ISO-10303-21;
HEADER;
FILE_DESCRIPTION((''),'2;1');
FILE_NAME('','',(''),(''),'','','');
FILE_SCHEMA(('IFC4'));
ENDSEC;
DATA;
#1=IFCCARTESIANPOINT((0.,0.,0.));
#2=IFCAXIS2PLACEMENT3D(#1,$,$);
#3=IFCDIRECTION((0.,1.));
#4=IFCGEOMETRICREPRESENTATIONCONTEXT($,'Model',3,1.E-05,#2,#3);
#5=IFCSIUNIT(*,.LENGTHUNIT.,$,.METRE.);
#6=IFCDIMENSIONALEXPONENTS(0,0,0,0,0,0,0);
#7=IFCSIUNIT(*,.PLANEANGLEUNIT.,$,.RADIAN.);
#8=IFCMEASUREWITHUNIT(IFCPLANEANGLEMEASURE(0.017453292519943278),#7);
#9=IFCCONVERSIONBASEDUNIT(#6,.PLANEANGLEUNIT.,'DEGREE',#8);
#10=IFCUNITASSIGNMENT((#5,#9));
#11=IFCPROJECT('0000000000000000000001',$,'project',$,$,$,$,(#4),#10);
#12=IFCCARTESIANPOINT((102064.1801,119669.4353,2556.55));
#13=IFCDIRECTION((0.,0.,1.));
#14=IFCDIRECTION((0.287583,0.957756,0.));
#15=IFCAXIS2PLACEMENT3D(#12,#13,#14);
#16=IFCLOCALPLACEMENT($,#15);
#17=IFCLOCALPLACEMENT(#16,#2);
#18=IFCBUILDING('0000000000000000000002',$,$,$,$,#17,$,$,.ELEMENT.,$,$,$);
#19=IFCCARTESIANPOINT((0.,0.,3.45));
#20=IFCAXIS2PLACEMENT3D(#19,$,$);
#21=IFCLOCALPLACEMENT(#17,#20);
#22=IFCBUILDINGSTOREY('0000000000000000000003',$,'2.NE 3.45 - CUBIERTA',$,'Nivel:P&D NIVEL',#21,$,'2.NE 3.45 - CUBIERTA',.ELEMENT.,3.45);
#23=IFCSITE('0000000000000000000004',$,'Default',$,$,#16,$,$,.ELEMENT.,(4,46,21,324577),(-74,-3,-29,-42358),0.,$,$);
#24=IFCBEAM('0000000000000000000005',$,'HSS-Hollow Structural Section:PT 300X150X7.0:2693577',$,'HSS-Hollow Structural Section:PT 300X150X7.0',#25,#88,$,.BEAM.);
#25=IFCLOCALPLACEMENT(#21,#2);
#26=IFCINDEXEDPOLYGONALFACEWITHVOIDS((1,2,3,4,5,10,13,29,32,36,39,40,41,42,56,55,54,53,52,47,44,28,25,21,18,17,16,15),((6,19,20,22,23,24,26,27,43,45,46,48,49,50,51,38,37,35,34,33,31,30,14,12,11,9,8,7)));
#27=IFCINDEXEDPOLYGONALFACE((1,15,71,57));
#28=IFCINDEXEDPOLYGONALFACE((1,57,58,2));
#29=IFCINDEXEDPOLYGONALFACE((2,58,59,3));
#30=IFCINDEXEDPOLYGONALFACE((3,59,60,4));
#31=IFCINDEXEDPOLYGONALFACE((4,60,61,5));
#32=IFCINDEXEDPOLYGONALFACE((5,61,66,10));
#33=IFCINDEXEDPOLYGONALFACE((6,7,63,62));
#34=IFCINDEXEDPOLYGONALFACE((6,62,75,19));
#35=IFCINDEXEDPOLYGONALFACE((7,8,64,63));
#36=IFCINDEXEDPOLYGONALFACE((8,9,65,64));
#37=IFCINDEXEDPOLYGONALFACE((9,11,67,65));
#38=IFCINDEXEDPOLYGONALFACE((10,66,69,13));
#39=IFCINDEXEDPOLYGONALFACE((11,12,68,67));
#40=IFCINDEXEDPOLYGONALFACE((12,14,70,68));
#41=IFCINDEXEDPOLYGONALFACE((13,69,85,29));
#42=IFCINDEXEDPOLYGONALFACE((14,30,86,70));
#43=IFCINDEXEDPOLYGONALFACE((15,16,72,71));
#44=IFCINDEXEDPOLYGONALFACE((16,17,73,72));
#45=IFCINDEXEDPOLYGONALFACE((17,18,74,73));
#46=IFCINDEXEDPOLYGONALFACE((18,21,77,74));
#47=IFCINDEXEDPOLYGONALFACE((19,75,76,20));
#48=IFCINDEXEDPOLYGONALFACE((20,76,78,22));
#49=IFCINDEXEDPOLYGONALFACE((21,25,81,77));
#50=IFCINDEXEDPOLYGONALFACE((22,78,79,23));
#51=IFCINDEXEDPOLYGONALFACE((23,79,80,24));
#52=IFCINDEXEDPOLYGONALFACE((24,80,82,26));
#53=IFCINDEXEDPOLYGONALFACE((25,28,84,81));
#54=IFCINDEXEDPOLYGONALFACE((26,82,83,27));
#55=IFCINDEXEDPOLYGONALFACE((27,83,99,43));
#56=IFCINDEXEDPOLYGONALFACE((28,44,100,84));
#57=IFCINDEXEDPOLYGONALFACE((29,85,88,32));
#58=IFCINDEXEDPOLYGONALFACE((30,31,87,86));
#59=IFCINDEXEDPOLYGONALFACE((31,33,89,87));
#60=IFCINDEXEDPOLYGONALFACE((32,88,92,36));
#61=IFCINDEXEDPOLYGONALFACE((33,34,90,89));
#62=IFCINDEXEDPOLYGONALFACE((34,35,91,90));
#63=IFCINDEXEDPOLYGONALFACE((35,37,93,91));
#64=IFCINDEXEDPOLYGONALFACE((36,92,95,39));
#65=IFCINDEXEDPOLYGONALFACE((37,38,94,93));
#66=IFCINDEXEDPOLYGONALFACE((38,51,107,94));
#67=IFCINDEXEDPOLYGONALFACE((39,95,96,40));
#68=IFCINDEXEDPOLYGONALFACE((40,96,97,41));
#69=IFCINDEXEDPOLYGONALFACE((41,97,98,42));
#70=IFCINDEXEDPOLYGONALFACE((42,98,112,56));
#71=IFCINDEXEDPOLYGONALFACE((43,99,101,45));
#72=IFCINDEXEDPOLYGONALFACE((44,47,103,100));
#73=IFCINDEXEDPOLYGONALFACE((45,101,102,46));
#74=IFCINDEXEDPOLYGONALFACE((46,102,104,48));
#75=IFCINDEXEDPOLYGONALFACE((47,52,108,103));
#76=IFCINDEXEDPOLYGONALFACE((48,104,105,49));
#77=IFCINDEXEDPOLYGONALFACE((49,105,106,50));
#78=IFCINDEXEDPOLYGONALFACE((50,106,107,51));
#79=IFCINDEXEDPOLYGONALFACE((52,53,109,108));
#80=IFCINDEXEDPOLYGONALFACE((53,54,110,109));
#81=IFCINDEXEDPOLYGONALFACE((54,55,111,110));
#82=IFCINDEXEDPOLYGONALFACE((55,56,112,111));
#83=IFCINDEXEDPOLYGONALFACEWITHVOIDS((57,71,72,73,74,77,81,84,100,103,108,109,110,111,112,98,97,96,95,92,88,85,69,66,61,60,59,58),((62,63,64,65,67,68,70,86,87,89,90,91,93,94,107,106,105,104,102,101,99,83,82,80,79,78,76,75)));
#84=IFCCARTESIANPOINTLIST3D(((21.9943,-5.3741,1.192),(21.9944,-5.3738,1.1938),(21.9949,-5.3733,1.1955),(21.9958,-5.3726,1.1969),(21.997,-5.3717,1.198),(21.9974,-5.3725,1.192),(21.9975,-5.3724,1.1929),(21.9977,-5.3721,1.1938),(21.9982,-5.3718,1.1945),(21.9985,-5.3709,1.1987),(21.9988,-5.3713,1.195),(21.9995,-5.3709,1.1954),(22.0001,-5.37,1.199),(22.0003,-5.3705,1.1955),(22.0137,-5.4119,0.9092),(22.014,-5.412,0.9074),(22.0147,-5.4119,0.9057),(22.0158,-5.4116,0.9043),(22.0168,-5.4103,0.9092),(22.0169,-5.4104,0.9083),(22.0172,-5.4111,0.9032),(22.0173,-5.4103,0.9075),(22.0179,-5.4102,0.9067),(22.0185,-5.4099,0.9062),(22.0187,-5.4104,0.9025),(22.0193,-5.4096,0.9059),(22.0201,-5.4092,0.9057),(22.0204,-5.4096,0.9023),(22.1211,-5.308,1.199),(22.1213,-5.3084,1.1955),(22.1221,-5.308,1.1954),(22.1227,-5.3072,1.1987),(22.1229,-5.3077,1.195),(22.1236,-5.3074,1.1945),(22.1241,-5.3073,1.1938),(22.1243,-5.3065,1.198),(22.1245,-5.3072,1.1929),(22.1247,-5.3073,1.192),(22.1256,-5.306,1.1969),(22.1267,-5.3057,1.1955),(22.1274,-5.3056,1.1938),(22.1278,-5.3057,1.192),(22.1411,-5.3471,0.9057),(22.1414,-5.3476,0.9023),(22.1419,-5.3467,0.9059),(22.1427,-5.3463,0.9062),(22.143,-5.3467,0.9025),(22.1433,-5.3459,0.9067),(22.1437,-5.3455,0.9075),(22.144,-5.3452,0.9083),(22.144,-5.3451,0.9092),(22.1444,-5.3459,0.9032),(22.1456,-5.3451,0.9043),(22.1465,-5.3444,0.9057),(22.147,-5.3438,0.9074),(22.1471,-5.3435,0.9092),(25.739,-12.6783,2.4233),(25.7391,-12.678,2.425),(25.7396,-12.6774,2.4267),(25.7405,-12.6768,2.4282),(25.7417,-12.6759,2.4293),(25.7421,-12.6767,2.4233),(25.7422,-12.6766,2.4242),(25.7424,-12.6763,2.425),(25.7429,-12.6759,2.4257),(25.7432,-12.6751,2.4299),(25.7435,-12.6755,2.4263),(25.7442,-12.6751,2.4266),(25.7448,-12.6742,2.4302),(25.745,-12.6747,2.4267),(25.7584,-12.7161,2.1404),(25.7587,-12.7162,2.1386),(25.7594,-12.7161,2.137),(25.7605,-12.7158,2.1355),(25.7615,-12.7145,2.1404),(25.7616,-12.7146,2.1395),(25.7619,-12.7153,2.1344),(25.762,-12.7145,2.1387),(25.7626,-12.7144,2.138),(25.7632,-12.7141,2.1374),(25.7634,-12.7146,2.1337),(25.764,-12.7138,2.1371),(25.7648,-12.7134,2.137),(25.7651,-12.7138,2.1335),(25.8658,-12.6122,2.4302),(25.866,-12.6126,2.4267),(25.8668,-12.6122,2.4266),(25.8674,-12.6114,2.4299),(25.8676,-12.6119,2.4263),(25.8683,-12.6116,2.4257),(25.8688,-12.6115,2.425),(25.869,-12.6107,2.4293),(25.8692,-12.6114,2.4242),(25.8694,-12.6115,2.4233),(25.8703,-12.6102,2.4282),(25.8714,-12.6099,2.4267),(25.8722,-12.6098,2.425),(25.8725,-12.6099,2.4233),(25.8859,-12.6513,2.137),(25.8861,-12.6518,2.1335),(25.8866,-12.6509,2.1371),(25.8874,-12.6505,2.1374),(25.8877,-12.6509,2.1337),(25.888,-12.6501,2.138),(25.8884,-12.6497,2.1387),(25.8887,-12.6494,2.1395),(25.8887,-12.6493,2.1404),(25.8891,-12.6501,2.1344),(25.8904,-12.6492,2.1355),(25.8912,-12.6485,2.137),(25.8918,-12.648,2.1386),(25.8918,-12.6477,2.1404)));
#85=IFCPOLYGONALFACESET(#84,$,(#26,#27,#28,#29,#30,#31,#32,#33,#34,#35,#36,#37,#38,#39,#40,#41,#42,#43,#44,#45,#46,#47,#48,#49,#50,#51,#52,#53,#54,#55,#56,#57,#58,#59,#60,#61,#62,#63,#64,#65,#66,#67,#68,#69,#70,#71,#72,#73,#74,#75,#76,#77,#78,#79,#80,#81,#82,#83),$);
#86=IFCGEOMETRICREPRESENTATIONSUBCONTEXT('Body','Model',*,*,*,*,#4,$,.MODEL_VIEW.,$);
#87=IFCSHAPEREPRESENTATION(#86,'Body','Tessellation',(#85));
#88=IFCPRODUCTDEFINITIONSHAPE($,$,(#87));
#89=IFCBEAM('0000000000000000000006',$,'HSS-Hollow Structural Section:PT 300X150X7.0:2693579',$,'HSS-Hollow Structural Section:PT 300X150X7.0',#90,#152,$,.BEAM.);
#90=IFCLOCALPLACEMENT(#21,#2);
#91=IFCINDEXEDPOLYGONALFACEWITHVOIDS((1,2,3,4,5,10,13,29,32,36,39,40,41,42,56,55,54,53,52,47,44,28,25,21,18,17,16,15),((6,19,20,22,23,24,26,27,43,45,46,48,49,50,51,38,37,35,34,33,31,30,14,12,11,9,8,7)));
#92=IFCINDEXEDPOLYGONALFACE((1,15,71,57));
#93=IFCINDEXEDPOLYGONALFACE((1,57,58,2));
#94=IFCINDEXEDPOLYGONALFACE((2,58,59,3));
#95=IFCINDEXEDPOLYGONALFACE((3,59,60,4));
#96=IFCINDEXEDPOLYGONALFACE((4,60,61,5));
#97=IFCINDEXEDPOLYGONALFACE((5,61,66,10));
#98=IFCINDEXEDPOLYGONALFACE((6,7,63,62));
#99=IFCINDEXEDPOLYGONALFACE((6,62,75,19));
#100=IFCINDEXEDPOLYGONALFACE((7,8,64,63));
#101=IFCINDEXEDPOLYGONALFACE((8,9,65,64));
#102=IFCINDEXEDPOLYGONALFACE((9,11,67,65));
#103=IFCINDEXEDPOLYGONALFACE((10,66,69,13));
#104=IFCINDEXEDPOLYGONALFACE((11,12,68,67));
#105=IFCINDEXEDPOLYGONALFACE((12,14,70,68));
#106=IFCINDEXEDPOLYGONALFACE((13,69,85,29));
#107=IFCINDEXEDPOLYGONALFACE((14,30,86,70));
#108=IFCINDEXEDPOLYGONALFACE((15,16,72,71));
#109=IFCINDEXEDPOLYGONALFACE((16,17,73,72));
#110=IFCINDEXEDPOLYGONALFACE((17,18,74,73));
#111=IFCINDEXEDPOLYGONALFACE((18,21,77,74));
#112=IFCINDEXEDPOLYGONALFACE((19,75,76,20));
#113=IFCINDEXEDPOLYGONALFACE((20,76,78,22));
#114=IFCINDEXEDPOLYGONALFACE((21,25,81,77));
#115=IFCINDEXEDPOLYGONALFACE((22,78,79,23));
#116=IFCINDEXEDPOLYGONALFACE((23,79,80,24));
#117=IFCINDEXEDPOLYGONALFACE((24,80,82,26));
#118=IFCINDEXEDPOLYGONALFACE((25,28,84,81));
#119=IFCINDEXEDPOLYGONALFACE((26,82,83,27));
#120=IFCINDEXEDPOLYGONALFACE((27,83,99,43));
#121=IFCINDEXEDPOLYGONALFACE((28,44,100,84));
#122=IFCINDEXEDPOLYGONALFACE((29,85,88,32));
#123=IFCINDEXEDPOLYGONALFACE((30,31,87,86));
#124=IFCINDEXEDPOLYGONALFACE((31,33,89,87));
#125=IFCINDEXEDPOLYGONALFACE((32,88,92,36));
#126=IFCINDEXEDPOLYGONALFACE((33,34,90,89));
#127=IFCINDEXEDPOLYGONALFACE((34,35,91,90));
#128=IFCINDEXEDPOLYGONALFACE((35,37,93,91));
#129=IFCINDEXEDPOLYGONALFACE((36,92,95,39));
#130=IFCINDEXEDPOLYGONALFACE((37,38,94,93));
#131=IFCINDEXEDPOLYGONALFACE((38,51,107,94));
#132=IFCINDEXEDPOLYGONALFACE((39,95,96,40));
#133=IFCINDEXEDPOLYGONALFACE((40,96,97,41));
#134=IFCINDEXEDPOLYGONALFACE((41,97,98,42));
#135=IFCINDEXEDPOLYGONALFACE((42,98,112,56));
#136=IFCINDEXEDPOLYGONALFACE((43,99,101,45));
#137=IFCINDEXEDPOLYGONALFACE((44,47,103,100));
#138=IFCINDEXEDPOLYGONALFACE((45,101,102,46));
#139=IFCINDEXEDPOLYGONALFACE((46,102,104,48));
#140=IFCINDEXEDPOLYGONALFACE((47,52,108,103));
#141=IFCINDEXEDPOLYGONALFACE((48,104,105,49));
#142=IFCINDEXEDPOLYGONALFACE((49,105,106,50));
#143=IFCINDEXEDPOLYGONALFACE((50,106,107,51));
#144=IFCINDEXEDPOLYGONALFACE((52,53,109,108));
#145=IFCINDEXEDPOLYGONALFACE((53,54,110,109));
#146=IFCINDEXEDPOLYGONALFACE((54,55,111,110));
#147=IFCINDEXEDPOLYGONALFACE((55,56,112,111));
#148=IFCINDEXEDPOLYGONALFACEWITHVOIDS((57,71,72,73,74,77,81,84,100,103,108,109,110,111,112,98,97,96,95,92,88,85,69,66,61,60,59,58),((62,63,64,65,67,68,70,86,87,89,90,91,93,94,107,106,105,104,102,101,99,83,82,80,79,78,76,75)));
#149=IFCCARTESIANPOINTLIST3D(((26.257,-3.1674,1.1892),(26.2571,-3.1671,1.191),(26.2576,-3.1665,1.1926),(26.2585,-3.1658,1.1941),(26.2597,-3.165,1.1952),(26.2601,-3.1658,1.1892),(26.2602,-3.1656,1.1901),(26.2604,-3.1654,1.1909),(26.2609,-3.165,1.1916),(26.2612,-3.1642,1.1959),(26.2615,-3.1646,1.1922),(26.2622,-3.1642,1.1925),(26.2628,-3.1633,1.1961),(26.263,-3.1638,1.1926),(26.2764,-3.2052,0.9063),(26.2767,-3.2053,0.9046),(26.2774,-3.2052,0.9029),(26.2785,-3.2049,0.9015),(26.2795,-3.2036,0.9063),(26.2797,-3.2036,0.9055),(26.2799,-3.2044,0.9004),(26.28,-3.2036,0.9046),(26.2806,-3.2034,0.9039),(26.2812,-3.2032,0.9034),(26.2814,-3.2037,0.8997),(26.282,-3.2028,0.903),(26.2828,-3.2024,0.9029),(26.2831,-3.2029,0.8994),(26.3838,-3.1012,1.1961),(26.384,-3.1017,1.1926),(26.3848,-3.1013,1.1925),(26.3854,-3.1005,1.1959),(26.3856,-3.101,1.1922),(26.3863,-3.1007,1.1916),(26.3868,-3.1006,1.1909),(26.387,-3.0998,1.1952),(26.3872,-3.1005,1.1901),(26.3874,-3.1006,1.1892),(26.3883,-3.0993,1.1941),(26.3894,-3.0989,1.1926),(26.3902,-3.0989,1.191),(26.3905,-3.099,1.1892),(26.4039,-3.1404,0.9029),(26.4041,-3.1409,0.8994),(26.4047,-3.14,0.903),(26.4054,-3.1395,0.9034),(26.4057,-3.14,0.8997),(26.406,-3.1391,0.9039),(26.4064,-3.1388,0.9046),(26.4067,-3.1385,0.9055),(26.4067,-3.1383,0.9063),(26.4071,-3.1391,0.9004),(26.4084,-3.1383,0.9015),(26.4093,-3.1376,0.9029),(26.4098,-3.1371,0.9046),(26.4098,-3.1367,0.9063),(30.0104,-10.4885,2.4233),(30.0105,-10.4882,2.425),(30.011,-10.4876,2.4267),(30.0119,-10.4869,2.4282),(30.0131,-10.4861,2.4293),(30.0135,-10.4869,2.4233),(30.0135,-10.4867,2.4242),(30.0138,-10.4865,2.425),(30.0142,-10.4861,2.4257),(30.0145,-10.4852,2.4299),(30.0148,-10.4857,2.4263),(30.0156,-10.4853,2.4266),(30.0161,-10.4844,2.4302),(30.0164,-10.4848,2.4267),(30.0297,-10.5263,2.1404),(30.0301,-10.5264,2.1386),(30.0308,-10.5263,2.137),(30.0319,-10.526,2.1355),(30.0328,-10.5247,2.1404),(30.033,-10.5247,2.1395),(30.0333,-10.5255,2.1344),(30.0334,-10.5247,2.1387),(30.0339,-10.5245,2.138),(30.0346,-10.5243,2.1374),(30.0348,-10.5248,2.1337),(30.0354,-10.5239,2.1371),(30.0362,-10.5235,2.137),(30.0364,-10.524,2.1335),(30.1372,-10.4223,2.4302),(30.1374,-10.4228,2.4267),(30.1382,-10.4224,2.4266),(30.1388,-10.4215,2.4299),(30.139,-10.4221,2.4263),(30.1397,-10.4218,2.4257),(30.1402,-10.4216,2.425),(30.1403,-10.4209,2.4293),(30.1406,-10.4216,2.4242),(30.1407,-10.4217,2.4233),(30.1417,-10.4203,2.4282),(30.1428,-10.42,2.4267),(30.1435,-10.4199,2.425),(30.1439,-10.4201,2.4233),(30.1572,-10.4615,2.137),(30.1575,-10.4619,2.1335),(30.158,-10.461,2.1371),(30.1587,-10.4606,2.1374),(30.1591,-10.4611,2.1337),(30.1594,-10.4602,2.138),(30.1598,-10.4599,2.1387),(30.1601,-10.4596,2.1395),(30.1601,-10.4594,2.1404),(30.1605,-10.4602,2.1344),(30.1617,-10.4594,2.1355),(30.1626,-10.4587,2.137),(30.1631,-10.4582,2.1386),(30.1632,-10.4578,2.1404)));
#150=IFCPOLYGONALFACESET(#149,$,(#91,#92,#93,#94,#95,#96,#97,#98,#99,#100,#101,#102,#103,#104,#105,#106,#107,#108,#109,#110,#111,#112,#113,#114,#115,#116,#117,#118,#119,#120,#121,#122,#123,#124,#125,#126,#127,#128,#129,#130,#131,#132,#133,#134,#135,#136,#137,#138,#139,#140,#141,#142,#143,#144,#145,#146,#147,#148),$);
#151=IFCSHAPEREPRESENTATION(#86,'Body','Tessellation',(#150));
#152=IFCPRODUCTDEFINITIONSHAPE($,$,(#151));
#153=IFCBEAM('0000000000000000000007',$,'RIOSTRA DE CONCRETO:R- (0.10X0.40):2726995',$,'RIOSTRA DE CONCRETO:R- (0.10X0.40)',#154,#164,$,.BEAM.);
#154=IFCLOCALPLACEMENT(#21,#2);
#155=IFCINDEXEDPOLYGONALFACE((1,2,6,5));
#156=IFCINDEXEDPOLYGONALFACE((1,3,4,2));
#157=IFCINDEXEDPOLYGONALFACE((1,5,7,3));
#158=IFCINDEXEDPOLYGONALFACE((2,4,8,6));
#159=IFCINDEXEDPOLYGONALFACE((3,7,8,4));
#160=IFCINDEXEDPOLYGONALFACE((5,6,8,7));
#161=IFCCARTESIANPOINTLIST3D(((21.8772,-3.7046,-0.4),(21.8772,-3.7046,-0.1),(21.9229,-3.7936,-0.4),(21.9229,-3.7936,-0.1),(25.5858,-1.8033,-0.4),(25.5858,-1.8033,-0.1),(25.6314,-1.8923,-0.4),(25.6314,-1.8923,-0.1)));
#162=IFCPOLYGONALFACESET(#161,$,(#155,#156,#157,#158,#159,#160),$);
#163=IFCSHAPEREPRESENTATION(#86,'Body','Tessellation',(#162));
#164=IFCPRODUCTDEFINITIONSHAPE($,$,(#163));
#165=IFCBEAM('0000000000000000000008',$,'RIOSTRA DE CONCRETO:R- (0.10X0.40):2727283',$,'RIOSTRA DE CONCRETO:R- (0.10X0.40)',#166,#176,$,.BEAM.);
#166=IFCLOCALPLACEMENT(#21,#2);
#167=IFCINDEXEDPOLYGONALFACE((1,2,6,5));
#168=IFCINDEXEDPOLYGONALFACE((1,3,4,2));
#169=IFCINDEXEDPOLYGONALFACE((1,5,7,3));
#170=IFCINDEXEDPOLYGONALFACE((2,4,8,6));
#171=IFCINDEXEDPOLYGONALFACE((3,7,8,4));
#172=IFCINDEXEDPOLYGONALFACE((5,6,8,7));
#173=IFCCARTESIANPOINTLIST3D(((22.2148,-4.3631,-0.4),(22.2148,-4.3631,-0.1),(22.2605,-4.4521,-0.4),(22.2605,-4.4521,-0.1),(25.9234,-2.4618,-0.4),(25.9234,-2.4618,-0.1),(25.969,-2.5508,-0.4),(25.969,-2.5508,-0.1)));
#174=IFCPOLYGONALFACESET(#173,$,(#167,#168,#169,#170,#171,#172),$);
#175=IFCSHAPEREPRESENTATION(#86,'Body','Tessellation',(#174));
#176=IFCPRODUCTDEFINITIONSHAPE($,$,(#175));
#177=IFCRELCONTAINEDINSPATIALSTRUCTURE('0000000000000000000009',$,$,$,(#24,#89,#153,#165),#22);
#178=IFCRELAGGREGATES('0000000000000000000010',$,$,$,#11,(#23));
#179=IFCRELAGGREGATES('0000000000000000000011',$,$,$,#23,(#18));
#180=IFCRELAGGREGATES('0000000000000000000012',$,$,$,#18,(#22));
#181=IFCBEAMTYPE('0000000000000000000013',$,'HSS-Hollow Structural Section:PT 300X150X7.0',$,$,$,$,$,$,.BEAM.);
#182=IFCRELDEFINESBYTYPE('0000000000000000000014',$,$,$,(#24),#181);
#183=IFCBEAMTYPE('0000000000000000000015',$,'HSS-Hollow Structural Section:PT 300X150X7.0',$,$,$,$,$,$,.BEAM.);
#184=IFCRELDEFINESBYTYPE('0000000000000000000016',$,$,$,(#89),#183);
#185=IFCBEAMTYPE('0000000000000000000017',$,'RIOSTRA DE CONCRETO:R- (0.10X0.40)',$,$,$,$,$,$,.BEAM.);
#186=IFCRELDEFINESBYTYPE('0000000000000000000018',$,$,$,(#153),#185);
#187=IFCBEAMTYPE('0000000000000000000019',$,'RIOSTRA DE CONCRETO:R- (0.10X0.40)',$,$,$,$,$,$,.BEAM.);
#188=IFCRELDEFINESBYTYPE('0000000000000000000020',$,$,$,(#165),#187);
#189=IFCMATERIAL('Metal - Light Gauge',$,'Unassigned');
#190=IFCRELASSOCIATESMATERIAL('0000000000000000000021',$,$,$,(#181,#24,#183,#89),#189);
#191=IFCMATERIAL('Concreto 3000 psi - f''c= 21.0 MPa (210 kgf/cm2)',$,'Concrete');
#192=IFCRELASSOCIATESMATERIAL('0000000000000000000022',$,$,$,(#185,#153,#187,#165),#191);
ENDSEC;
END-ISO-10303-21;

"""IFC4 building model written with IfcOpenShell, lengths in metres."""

from ifc_helpers import new_model, entity, si_unit, converted_unit, direction, frame, origin, place, context, subcontext, project, spatial, line, arc, indexed_curve, outline, extrude, source, transform, mapped, material, type_object, type_shapes, element, save


model = new_model("IFC4")

# Units and contexts
model_context = context("Model", 3, precision=1e-05, world=origin(), true_north=direction((0.0, 1.0)))
body_context = subcontext(model_context, "Body", "Model", "MODEL_VIEW")
ifc_project = project(units=[si_unit("LENGTHUNIT", "METRE"), converted_unit("PLANEANGLEUNIT", "DEGREE", entity("IfcPlaneAngleMeasure", 0.017453292519943278), si_unit("PLANEANGLEUNIT", "RADIAN"), dimensions=[0, 0, 0, 0, 0, 0, 0])], contexts=[model_context])

# Site, building, storey
site_placement = place(None, frame((102064.1801, 119669.4353, 2556.55), z_axis=(0.0, 0.0, 1.0), x_axis=(0.287583, 0.957756, 0.0)))
site = spatial("IfcSite", under=ifc_project, at=site_placement, Name="Default", CompositionType="ELEMENT", RefLatitude=(4, 46, 21, 324577), RefLongitude=(-74, -3, -29, -42358), RefElevation=0.0)
building_placement = place(site_placement, origin())
building = spatial("IfcBuilding", under=site, at=building_placement, CompositionType="ELEMENT")
storey_placement = place(building_placement, frame((0.0, 0.0, 3.45)))
storey = spatial("IfcBuildingStorey", under=building, at=storey_placement, Name="2.NE 3.45 - CUBIERTA", ObjectType="Nivel:P&D NIVEL", LongName="2.NE 3.45 - CUBIERTA", CompositionType="ELEMENT", Elevation=3.45)

# Beams
ifc_material_1 = material(Name="Metal - Light Gauge", Category="Unassigned")
beam_type_1 = type_object("IfcBeamType", Name="HSS-Hollow Structural Section:PT 300X150X7.0", PredefinedType="BEAM", material=ifc_material_1)
shared_shape_1 = source(origin(), body_context, "Body", "SweptSolid", [
    extrude(outline(indexed_curve([(0.143, -0.075), (0.1479, -0.0729), (0.15, -0.068), (0.15, 0.068), (0.1479, 0.0729), (0.143, 0.075), (-0.143, 0.075), (-0.1479, 0.0729), (-0.15, 0.068), (-0.15, -0.068), (-0.1479, -0.0729), (-0.143, -0.075)], segments=[arc(1, 2, 3), line(3, 4), arc(4, 5, 6), line(6, 7), arc(7, 8, 9), line(9, 10), arc(10, 11, 12), line(12, 1)], self_intersect=False), holes=[indexed_curve([(0.1465, 0.068), (0.1465, -0.068), (0.1455, -0.0705), (0.143, -0.0715), (-0.143, -0.0715), (-0.1455, -0.0705), (-0.1465, -0.068), (-0.1465, 0.068), (-0.1455, 0.0705), (-0.143, 0.0715), (0.143, 0.0715), (0.1455, 0.0705)], segments=[line(1, 2), arc(2, 3, 4), line(4, 5), arc(5, 6, 7), line(7, 8), arc(8, 9, 10), line(10, 11), arc(11, 12, 1)], self_intersect=False)]), frame((25.8154, -12.663, 5.7318), z_axis=(-0.451169, 0.880024, -0.14834), x_axis=(-0.067675, 0.132004, 0.988936)), (0.0, 0.0, 1.0), 8.3),
])
type_shapes(beam_type_1, [shared_shape_1])
beam_1_placement = place(storey_placement, frame((0.0, 0.0, -3.45)))
element("IfcBeam", 1, at=beam_1_placement, inside=storey, type_object=beam_type_1, material=ifc_material_1, Name="HSS-Hollow Structural Section:PT 300X150X7.0:2693577", ObjectType="HSS-Hollow Structural Section:PT 300X150X7.0", PredefinedType="BEAM", context=body_context, shape_type="MappedRepresentation", body=[
    mapped(shared_shape_1, transform((0.0, 0.0, 0.0), scale=1.0)),
])
beam_type_2 = type_object("IfcBeamType", Name="HSS-Hollow Structural Section:PT 300X150X7.0", PredefinedType="BEAM", material=ifc_material_1)
shared_shape_2 = source(origin(), body_context, "Body", "SweptSolid", [
    extrude(outline(indexed_curve([(0.143, -0.075), (0.1479, -0.0729), (0.15, -0.068), (0.15, 0.068), (0.1479, 0.0729), (0.143, 0.075), (-0.143, 0.075), (-0.1479, 0.0729), (-0.15, 0.068), (-0.15, -0.068), (-0.1479, -0.0729), (-0.143, -0.075)], segments=[arc(1, 2, 3), line(3, 4), arc(4, 5, 6), line(6, 7), arc(7, 8, 9), line(9, 10), arc(10, 11, 12), line(12, 1)], self_intersect=False), holes=[indexed_curve([(0.1465, 0.068), (0.1465, -0.068), (0.1455, -0.0705), (0.143, -0.0715), (-0.143, -0.0715), (-0.1455, -0.0705), (-0.1465, -0.068), (-0.1465, 0.068), (-0.1455, 0.0705), (-0.143, 0.0715), (0.143, 0.0715), (0.1455, 0.0705)], segments=[line(1, 2), arc(2, 3, 4), line(4, 5), arc(5, 6, 7), line(7, 8), arc(8, 9, 10), line(10, 11), arc(11, 12, 1)], self_intersect=False)]), frame((30.0868, -10.4732, 5.7318), z_axis=(-0.451169, 0.880024, -0.14834), x_axis=(-0.067675, 0.132004, 0.988936)), (0.0, 0.0, 1.0), 8.3192),
])
type_shapes(beam_type_2, [shared_shape_2])
beam_2_placement = place(storey_placement, frame((0.0, 0.0, -3.45)))
element("IfcBeam", 2, at=beam_2_placement, inside=storey, type_object=beam_type_2, material=ifc_material_1, Name="HSS-Hollow Structural Section:PT 300X150X7.0:2693579", ObjectType="HSS-Hollow Structural Section:PT 300X150X7.0", PredefinedType="BEAM", context=body_context, shape_type="MappedRepresentation", body=[
    mapped(shared_shape_2, transform((0.0, 0.0, 0.0), scale=1.0)),
])
ifc_material_2 = material(Name="Concreto 3000 psi - f'c= 21.0 MPa (210 kgf/cm2)", Category="Concrete")
beam_type_3 = type_object("IfcBeamType", Name="RIOSTRA DE CONCRETO:R- (0.10X0.40)", PredefinedType="BEAM", material=ifc_material_2)
shared_shape_3 = source(origin(), body_context, "Body", "SweptSolid", [
    extrude(outline(indexed_curve([(-0.15, -0.05), (0.15, -0.05), (0.15, 0.05), (-0.15, 0.05), (-0.15, -0.05)], self_intersect=False)), frame((21.9001, -3.7491, 3.2), z_axis=(0.889869, 0.456217, 0.0), x_axis=(0.0, 0.0, 1.0)), (0.0, 0.0, 1.0), 4.1675),
])
type_shapes(beam_type_3, [shared_shape_3])
beam_3_placement = place(storey_placement, frame((0.0, 0.0, -3.45)))
element("IfcBeam", 3, at=beam_3_placement, inside=storey, type_object=beam_type_3, material=ifc_material_2, Name="RIOSTRA DE CONCRETO:R- (0.10X0.40):2726995", ObjectType="RIOSTRA DE CONCRETO:R- (0.10X0.40)", PredefinedType="BEAM", context=body_context, shape_type="MappedRepresentation", body=[
    mapped(shared_shape_3, transform((0.0, 0.0, 0.0), scale=1.0)),
])
beam_type_4 = type_object("IfcBeamType", Name="RIOSTRA DE CONCRETO:R- (0.10X0.40)", PredefinedType="BEAM", material=ifc_material_2)
shared_shape_4 = source(origin(), body_context, "Body", "SweptSolid", [
    extrude(outline(indexed_curve([(-0.15, -0.05), (0.15, -0.05), (0.15, 0.05), (-0.15, 0.05), (-0.15, -0.05)], self_intersect=False)), frame((22.2377, -4.4076, 3.2), z_axis=(0.889869, 0.456217, 0.0), x_axis=(0.0, 0.0, 1.0)), (0.0, 0.0, 1.0), 4.1675),
])
type_shapes(beam_type_4, [shared_shape_4])
beam_4_placement = place(storey_placement, frame((0.0, 0.0, -3.45)))
element("IfcBeam", 4, at=beam_4_placement, inside=storey, type_object=beam_type_4, material=ifc_material_2, Name="RIOSTRA DE CONCRETO:R- (0.10X0.40):2727283", ObjectType="RIOSTRA DE CONCRETO:R- (0.10X0.40)", PredefinedType="BEAM", context=body_context, shape_type="MappedRepresentation", body=[
    mapped(shared_shape_4, transform((0.0, 0.0, 0.0), scale=1.0)),
])

save(model, "model.ifc")
